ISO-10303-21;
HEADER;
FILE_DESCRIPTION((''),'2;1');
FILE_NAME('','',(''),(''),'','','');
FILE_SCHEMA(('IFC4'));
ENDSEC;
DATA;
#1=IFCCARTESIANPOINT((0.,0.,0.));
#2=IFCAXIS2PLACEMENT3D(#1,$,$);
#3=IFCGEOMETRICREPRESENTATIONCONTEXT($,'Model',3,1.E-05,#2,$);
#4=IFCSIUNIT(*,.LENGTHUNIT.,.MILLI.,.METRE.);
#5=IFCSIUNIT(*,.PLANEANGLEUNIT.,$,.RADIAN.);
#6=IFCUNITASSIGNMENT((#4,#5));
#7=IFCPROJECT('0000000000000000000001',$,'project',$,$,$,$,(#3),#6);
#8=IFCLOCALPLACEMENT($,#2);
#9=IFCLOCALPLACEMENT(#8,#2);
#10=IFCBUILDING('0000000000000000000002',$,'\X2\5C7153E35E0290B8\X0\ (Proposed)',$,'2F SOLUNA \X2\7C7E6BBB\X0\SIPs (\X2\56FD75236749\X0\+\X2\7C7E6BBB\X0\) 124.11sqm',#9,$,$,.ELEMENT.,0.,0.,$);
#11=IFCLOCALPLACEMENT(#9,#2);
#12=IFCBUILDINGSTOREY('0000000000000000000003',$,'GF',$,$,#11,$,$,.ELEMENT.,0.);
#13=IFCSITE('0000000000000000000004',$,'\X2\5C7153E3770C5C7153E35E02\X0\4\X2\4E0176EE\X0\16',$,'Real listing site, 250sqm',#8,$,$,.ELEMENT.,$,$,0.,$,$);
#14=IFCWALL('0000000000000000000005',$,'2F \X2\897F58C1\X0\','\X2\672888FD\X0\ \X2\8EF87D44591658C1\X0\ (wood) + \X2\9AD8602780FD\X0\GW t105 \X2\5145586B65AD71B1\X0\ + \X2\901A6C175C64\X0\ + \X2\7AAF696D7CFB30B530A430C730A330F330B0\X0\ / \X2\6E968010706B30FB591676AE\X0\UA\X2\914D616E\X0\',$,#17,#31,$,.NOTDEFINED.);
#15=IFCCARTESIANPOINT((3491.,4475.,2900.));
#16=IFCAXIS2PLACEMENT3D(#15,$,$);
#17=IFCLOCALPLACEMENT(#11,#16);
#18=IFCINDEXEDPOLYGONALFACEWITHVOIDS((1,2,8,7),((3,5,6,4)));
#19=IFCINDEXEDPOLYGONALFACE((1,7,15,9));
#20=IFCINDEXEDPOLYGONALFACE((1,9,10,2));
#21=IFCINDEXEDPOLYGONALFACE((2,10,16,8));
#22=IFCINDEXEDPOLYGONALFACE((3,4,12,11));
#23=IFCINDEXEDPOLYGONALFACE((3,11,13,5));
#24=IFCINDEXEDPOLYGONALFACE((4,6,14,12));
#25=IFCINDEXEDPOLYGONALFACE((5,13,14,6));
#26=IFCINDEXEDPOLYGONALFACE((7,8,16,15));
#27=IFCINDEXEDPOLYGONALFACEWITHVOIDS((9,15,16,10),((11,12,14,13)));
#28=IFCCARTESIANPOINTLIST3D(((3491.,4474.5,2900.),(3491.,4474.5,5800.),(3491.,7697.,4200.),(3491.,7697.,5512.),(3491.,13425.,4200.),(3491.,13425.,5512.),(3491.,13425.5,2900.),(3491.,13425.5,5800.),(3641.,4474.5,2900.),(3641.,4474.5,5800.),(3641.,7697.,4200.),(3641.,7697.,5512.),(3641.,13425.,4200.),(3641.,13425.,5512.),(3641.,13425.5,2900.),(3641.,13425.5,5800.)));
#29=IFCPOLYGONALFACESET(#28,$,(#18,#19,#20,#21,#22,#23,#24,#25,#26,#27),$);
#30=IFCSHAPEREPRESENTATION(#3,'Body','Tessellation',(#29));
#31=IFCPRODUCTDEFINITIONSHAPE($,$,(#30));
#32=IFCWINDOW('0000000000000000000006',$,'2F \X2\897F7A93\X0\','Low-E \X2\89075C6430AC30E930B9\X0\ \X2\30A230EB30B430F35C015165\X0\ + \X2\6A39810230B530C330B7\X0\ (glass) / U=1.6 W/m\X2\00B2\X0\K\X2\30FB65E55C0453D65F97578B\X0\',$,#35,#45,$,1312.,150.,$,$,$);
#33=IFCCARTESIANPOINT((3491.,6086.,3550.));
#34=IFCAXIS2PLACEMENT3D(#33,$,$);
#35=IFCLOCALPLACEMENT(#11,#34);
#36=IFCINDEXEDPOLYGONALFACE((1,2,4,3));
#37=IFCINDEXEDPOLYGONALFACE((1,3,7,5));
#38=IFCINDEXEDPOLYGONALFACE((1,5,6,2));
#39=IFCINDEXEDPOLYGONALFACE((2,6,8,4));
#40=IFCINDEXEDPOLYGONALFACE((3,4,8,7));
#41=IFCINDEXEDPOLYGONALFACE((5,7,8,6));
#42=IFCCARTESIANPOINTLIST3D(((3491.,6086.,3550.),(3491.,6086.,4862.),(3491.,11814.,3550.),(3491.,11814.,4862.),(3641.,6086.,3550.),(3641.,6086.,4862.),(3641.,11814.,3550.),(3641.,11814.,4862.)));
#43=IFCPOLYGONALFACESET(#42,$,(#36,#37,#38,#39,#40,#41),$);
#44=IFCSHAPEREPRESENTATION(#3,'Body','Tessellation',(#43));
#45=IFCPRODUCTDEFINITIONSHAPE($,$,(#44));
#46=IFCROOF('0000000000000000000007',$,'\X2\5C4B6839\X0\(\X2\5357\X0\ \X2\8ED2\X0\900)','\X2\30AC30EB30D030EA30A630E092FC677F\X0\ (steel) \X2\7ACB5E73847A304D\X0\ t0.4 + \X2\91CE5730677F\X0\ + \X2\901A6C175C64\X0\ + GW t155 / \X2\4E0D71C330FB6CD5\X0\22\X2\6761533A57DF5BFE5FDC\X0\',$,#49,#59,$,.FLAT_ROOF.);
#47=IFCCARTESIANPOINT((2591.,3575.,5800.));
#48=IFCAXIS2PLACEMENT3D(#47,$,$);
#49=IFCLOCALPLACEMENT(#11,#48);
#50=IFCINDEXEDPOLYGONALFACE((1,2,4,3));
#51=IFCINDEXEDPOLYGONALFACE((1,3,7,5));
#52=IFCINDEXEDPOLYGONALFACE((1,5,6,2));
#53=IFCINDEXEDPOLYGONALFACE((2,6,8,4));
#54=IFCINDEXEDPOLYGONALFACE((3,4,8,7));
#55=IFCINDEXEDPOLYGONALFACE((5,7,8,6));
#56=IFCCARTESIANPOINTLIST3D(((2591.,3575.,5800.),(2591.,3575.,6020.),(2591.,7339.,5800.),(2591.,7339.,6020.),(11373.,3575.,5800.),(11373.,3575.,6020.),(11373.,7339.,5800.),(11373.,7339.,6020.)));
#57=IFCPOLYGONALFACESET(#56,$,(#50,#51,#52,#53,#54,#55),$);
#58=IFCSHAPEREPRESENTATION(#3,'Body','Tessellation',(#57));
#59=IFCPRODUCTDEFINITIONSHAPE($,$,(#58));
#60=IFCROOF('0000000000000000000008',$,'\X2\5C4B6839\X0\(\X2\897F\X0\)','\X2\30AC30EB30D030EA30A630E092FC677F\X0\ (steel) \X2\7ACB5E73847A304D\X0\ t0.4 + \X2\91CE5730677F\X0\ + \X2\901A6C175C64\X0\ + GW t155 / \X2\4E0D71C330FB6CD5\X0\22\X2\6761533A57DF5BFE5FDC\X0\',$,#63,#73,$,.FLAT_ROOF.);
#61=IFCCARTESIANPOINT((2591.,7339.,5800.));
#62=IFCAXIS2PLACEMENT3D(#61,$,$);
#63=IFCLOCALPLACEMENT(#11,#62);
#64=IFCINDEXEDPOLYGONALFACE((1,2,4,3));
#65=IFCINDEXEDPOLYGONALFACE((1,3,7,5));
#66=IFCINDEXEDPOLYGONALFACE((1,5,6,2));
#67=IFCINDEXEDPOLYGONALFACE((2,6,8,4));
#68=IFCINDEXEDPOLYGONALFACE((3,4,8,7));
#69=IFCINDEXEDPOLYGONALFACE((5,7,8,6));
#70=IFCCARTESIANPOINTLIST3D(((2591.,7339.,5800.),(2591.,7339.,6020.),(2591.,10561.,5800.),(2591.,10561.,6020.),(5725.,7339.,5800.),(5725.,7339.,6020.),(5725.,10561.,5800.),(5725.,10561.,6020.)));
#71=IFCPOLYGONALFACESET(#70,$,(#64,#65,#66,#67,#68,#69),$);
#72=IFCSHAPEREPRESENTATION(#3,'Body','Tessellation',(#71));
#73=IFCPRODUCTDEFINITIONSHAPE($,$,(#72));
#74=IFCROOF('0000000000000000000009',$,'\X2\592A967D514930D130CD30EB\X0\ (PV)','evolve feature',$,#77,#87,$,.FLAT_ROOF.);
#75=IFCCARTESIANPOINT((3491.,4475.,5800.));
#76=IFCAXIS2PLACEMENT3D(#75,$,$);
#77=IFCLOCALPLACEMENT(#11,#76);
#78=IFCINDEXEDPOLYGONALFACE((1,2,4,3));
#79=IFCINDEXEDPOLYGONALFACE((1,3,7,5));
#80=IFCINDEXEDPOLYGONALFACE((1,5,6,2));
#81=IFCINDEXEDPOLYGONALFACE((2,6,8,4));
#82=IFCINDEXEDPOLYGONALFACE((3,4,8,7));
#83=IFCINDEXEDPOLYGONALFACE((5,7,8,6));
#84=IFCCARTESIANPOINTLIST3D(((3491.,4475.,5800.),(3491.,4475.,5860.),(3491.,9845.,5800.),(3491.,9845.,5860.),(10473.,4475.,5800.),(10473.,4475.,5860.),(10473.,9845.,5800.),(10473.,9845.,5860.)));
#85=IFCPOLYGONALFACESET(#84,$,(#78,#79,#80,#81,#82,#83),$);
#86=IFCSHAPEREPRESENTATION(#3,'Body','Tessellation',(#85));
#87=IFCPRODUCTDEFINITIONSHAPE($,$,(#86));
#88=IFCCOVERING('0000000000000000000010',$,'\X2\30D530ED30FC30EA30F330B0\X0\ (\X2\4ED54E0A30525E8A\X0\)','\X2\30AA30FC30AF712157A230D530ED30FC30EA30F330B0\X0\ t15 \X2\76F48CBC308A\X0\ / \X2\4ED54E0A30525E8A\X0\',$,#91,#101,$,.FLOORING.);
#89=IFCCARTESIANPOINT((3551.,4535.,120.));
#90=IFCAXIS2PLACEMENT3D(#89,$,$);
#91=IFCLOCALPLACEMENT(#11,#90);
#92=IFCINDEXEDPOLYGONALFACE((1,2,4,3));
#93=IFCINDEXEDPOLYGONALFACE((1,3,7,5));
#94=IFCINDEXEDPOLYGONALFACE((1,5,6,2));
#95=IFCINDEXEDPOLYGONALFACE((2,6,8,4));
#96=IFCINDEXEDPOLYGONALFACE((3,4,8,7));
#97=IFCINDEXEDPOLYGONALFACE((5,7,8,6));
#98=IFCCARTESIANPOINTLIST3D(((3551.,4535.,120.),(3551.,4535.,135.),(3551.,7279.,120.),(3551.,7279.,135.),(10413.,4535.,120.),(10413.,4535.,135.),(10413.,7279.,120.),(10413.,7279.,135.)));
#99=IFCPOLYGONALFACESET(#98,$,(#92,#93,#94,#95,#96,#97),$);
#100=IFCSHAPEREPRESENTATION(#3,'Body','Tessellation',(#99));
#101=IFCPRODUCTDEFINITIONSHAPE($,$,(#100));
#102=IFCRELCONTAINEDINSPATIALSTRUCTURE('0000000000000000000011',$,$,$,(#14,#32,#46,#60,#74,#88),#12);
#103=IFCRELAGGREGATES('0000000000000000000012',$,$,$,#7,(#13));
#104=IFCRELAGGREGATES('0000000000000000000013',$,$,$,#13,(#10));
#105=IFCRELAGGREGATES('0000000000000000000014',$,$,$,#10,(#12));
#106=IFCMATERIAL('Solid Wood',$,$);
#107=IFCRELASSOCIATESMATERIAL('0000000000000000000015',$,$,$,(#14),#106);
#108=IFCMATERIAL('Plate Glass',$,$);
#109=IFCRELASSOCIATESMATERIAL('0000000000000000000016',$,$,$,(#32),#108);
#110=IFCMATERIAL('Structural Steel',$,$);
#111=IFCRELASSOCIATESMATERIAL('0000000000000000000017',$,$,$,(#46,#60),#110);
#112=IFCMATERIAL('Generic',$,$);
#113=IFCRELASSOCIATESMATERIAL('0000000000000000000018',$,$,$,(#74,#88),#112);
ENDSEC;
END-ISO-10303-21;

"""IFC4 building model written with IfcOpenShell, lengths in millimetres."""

from ifc_helpers import new_model, si_unit, frame, frame_2d, origin, place, context, project, spatial, rectangle, extrude, material, element, fill, save


model = new_model("IFC4")

# Units and contexts
model_context = context("Model", 3, precision=1e-05, world=origin())
ifc_project = project(units=[si_unit("LENGTHUNIT", "METRE", prefix="MILLI"), si_unit("PLANEANGLEUNIT", "RADIAN")], contexts=[model_context])

# Site, building, storey
site_placement = place(None, origin())
site = spatial("IfcSite", under=ifc_project, at=site_placement, Name="山口県山口市4丁目16", ObjectType="Real listing site, 250sqm", CompositionType="ELEMENT", RefElevation=0.0)
building_placement = place(site_placement, origin())
building = spatial("IfcBuilding", under=site, at=building_placement, Name="山口市邸 (Proposed)", ObjectType="2F SOLUNA 籾殻SIPs (国産杉+籾殻) 124.11sqm", CompositionType="ELEMENT", ElevationOfRefHeight=0.0, ElevationOfTerrain=0.0)
storey_placement = place(building_placement, origin())
storey = spatial("IfcBuildingStorey", under=building, at=storey_placement, Name="GF", CompositionType="ELEMENT", Elevation=0.0)

# Shared definitions
ifc_material_1 = material(Name="Solid Wood")
ifc_material_2 = material(Name="Generic")

# Shared definitions
ifc_material_3 = material(Name="Plate Glass")

# Wall, opening, window
wall_1_placement = place(storey_placement, frame((3491.0, 4475.0, 2900.0)))
wall_1 = element("IfcWall", 1, at=wall_1_placement, inside=storey, material=ifc_material_1, Name="2F 西壁", Description="木製 軸組外壁 (wood) + 高性能GW t105 充填断熱 + 通気層 + 窯業系サイディング / 準耐火・外皮UA配慮", PredefinedType="NOTDEFINED", context=model_context, shape_type="SweptSolid", body=[
    extrude(rectangle(XDim=150.0, YDim=8951.0, at=frame_2d((75.0, 4475.0))), frame((3491.0, 4475.0, 2900.0)), (0.0, 0.0, 1.0), 2900.0),
])
opening_1_placement = place(storey_placement, frame((3491.0, 6086.0, 3550.0)))
opening_1 = element("IfcOpeningElement", 2, at=opening_1_placement, cuts=wall_1, PredefinedType="NOTDEFINED", context=model_context, shape_type="SweptSolid", body=[
    extrude(rectangle(XDim=150.0, YDim=5728.0, at=frame_2d((75.0, 2864.0))), frame((3491.0, 6086.0, 3550.0)), (0.0, 0.0, 1.0), 1312.0),
])
window_1_placement = place(storey_placement, frame((3491.0, 6086.0, 3550.0)))
window_1 = element("IfcWindow", 3, at=window_1_placement, inside=storey, material=ifc_material_3, Name="2F 西窓", Description="Low-E 複層ガラス アルゴン封入 + 樹脂サッシ (glass) / U=1.6 W/m²K・日射取得型", OverallHeight=1312.0, OverallWidth=150.0, context=model_context, shape_type="SweptSolid", body=[
    extrude(rectangle(XDim=150.0, YDim=5728.0, at=frame_2d((75.0, 2864.0))), frame((3491.0, 6086.0, 3550.0)), (0.0, 0.0, 1.0), 1312.0),
])
fill(opening_1, window_1)

# Roofs
ifc_material_4 = material(Name="Structural Steel")
roof_1_placement = place(storey_placement, frame((2591.0, 3575.0, 5800.0)))
element("IfcRoof", 4, at=roof_1_placement, inside=storey, material=ifc_material_4, Name="屋根(南 軒900)", Description="ガルバリウム鋼板 (steel) 立平葺き t0.4 + 野地板 + 通気層 + GW t155 / 不燃・法22条区域対応", PredefinedType="FLAT_ROOF", context=model_context, shape_type="SweptSolid", body=[
    extrude(rectangle(XDim=8782.0, YDim=3764.0, at=frame_2d((4391.0, 1882.0))), frame((2591.0, 3575.0, 5800.0)), (0.0, 0.0, 1.0), 220.0),
])
roof_2_placement = place(storey_placement, frame((2591.0, 7339.0, 5800.0)))
element("IfcRoof", 5, at=roof_2_placement, inside=storey, material=ifc_material_4, Name="屋根(西)", Description="ガルバリウム鋼板 (steel) 立平葺き t0.4 + 野地板 + 通気層 + GW t155 / 不燃・法22条区域対応", PredefinedType="FLAT_ROOF", context=model_context, shape_type="SweptSolid", body=[
    extrude(rectangle(XDim=3134.0, YDim=3222.0, at=frame_2d((1567.0, 1611.0))), frame((2591.0, 7339.0, 5800.0)), (0.0, 0.0, 1.0), 220.0),
])
roof_3_placement = place(storey_placement, frame((3491.0, 4475.0, 5800.0)))
element("IfcRoof", 6, at=roof_3_placement, inside=storey, material=ifc_material_2, Name="太陽光パネル (PV)", Description="evolve feature", PredefinedType="FLAT_ROOF", context=model_context, shape_type="SweptSolid", body=[
    extrude(rectangle(XDim=6982.0, YDim=5370.0, at=frame_2d((3491.0, 2685.0))), frame((3491.0, 4475.0, 5800.0)), (0.0, 0.0, 1.0), 60.0),
])

# Covering
covering_placement = place(storey_placement, frame((3551.0, 4535.0, 120.0)))
element("IfcCovering", 7, at=covering_placement, inside=storey, material=ifc_material_2, Name="フローリング (仕上げ床)", Description="オーク無垢フローリング t15 直貼り / 仕上げ床", PredefinedType="FLOORING", context=model_context, shape_type="SweptSolid", body=[
    extrude(rectangle(XDim=6862.0, YDim=2744.0, at=frame_2d((3431.0, 1372.0))), frame((3551.0, 4535.0, 120.0)), (0.0, 0.0, 1.0), 15.0),
])

save(model, "model.ifc")
